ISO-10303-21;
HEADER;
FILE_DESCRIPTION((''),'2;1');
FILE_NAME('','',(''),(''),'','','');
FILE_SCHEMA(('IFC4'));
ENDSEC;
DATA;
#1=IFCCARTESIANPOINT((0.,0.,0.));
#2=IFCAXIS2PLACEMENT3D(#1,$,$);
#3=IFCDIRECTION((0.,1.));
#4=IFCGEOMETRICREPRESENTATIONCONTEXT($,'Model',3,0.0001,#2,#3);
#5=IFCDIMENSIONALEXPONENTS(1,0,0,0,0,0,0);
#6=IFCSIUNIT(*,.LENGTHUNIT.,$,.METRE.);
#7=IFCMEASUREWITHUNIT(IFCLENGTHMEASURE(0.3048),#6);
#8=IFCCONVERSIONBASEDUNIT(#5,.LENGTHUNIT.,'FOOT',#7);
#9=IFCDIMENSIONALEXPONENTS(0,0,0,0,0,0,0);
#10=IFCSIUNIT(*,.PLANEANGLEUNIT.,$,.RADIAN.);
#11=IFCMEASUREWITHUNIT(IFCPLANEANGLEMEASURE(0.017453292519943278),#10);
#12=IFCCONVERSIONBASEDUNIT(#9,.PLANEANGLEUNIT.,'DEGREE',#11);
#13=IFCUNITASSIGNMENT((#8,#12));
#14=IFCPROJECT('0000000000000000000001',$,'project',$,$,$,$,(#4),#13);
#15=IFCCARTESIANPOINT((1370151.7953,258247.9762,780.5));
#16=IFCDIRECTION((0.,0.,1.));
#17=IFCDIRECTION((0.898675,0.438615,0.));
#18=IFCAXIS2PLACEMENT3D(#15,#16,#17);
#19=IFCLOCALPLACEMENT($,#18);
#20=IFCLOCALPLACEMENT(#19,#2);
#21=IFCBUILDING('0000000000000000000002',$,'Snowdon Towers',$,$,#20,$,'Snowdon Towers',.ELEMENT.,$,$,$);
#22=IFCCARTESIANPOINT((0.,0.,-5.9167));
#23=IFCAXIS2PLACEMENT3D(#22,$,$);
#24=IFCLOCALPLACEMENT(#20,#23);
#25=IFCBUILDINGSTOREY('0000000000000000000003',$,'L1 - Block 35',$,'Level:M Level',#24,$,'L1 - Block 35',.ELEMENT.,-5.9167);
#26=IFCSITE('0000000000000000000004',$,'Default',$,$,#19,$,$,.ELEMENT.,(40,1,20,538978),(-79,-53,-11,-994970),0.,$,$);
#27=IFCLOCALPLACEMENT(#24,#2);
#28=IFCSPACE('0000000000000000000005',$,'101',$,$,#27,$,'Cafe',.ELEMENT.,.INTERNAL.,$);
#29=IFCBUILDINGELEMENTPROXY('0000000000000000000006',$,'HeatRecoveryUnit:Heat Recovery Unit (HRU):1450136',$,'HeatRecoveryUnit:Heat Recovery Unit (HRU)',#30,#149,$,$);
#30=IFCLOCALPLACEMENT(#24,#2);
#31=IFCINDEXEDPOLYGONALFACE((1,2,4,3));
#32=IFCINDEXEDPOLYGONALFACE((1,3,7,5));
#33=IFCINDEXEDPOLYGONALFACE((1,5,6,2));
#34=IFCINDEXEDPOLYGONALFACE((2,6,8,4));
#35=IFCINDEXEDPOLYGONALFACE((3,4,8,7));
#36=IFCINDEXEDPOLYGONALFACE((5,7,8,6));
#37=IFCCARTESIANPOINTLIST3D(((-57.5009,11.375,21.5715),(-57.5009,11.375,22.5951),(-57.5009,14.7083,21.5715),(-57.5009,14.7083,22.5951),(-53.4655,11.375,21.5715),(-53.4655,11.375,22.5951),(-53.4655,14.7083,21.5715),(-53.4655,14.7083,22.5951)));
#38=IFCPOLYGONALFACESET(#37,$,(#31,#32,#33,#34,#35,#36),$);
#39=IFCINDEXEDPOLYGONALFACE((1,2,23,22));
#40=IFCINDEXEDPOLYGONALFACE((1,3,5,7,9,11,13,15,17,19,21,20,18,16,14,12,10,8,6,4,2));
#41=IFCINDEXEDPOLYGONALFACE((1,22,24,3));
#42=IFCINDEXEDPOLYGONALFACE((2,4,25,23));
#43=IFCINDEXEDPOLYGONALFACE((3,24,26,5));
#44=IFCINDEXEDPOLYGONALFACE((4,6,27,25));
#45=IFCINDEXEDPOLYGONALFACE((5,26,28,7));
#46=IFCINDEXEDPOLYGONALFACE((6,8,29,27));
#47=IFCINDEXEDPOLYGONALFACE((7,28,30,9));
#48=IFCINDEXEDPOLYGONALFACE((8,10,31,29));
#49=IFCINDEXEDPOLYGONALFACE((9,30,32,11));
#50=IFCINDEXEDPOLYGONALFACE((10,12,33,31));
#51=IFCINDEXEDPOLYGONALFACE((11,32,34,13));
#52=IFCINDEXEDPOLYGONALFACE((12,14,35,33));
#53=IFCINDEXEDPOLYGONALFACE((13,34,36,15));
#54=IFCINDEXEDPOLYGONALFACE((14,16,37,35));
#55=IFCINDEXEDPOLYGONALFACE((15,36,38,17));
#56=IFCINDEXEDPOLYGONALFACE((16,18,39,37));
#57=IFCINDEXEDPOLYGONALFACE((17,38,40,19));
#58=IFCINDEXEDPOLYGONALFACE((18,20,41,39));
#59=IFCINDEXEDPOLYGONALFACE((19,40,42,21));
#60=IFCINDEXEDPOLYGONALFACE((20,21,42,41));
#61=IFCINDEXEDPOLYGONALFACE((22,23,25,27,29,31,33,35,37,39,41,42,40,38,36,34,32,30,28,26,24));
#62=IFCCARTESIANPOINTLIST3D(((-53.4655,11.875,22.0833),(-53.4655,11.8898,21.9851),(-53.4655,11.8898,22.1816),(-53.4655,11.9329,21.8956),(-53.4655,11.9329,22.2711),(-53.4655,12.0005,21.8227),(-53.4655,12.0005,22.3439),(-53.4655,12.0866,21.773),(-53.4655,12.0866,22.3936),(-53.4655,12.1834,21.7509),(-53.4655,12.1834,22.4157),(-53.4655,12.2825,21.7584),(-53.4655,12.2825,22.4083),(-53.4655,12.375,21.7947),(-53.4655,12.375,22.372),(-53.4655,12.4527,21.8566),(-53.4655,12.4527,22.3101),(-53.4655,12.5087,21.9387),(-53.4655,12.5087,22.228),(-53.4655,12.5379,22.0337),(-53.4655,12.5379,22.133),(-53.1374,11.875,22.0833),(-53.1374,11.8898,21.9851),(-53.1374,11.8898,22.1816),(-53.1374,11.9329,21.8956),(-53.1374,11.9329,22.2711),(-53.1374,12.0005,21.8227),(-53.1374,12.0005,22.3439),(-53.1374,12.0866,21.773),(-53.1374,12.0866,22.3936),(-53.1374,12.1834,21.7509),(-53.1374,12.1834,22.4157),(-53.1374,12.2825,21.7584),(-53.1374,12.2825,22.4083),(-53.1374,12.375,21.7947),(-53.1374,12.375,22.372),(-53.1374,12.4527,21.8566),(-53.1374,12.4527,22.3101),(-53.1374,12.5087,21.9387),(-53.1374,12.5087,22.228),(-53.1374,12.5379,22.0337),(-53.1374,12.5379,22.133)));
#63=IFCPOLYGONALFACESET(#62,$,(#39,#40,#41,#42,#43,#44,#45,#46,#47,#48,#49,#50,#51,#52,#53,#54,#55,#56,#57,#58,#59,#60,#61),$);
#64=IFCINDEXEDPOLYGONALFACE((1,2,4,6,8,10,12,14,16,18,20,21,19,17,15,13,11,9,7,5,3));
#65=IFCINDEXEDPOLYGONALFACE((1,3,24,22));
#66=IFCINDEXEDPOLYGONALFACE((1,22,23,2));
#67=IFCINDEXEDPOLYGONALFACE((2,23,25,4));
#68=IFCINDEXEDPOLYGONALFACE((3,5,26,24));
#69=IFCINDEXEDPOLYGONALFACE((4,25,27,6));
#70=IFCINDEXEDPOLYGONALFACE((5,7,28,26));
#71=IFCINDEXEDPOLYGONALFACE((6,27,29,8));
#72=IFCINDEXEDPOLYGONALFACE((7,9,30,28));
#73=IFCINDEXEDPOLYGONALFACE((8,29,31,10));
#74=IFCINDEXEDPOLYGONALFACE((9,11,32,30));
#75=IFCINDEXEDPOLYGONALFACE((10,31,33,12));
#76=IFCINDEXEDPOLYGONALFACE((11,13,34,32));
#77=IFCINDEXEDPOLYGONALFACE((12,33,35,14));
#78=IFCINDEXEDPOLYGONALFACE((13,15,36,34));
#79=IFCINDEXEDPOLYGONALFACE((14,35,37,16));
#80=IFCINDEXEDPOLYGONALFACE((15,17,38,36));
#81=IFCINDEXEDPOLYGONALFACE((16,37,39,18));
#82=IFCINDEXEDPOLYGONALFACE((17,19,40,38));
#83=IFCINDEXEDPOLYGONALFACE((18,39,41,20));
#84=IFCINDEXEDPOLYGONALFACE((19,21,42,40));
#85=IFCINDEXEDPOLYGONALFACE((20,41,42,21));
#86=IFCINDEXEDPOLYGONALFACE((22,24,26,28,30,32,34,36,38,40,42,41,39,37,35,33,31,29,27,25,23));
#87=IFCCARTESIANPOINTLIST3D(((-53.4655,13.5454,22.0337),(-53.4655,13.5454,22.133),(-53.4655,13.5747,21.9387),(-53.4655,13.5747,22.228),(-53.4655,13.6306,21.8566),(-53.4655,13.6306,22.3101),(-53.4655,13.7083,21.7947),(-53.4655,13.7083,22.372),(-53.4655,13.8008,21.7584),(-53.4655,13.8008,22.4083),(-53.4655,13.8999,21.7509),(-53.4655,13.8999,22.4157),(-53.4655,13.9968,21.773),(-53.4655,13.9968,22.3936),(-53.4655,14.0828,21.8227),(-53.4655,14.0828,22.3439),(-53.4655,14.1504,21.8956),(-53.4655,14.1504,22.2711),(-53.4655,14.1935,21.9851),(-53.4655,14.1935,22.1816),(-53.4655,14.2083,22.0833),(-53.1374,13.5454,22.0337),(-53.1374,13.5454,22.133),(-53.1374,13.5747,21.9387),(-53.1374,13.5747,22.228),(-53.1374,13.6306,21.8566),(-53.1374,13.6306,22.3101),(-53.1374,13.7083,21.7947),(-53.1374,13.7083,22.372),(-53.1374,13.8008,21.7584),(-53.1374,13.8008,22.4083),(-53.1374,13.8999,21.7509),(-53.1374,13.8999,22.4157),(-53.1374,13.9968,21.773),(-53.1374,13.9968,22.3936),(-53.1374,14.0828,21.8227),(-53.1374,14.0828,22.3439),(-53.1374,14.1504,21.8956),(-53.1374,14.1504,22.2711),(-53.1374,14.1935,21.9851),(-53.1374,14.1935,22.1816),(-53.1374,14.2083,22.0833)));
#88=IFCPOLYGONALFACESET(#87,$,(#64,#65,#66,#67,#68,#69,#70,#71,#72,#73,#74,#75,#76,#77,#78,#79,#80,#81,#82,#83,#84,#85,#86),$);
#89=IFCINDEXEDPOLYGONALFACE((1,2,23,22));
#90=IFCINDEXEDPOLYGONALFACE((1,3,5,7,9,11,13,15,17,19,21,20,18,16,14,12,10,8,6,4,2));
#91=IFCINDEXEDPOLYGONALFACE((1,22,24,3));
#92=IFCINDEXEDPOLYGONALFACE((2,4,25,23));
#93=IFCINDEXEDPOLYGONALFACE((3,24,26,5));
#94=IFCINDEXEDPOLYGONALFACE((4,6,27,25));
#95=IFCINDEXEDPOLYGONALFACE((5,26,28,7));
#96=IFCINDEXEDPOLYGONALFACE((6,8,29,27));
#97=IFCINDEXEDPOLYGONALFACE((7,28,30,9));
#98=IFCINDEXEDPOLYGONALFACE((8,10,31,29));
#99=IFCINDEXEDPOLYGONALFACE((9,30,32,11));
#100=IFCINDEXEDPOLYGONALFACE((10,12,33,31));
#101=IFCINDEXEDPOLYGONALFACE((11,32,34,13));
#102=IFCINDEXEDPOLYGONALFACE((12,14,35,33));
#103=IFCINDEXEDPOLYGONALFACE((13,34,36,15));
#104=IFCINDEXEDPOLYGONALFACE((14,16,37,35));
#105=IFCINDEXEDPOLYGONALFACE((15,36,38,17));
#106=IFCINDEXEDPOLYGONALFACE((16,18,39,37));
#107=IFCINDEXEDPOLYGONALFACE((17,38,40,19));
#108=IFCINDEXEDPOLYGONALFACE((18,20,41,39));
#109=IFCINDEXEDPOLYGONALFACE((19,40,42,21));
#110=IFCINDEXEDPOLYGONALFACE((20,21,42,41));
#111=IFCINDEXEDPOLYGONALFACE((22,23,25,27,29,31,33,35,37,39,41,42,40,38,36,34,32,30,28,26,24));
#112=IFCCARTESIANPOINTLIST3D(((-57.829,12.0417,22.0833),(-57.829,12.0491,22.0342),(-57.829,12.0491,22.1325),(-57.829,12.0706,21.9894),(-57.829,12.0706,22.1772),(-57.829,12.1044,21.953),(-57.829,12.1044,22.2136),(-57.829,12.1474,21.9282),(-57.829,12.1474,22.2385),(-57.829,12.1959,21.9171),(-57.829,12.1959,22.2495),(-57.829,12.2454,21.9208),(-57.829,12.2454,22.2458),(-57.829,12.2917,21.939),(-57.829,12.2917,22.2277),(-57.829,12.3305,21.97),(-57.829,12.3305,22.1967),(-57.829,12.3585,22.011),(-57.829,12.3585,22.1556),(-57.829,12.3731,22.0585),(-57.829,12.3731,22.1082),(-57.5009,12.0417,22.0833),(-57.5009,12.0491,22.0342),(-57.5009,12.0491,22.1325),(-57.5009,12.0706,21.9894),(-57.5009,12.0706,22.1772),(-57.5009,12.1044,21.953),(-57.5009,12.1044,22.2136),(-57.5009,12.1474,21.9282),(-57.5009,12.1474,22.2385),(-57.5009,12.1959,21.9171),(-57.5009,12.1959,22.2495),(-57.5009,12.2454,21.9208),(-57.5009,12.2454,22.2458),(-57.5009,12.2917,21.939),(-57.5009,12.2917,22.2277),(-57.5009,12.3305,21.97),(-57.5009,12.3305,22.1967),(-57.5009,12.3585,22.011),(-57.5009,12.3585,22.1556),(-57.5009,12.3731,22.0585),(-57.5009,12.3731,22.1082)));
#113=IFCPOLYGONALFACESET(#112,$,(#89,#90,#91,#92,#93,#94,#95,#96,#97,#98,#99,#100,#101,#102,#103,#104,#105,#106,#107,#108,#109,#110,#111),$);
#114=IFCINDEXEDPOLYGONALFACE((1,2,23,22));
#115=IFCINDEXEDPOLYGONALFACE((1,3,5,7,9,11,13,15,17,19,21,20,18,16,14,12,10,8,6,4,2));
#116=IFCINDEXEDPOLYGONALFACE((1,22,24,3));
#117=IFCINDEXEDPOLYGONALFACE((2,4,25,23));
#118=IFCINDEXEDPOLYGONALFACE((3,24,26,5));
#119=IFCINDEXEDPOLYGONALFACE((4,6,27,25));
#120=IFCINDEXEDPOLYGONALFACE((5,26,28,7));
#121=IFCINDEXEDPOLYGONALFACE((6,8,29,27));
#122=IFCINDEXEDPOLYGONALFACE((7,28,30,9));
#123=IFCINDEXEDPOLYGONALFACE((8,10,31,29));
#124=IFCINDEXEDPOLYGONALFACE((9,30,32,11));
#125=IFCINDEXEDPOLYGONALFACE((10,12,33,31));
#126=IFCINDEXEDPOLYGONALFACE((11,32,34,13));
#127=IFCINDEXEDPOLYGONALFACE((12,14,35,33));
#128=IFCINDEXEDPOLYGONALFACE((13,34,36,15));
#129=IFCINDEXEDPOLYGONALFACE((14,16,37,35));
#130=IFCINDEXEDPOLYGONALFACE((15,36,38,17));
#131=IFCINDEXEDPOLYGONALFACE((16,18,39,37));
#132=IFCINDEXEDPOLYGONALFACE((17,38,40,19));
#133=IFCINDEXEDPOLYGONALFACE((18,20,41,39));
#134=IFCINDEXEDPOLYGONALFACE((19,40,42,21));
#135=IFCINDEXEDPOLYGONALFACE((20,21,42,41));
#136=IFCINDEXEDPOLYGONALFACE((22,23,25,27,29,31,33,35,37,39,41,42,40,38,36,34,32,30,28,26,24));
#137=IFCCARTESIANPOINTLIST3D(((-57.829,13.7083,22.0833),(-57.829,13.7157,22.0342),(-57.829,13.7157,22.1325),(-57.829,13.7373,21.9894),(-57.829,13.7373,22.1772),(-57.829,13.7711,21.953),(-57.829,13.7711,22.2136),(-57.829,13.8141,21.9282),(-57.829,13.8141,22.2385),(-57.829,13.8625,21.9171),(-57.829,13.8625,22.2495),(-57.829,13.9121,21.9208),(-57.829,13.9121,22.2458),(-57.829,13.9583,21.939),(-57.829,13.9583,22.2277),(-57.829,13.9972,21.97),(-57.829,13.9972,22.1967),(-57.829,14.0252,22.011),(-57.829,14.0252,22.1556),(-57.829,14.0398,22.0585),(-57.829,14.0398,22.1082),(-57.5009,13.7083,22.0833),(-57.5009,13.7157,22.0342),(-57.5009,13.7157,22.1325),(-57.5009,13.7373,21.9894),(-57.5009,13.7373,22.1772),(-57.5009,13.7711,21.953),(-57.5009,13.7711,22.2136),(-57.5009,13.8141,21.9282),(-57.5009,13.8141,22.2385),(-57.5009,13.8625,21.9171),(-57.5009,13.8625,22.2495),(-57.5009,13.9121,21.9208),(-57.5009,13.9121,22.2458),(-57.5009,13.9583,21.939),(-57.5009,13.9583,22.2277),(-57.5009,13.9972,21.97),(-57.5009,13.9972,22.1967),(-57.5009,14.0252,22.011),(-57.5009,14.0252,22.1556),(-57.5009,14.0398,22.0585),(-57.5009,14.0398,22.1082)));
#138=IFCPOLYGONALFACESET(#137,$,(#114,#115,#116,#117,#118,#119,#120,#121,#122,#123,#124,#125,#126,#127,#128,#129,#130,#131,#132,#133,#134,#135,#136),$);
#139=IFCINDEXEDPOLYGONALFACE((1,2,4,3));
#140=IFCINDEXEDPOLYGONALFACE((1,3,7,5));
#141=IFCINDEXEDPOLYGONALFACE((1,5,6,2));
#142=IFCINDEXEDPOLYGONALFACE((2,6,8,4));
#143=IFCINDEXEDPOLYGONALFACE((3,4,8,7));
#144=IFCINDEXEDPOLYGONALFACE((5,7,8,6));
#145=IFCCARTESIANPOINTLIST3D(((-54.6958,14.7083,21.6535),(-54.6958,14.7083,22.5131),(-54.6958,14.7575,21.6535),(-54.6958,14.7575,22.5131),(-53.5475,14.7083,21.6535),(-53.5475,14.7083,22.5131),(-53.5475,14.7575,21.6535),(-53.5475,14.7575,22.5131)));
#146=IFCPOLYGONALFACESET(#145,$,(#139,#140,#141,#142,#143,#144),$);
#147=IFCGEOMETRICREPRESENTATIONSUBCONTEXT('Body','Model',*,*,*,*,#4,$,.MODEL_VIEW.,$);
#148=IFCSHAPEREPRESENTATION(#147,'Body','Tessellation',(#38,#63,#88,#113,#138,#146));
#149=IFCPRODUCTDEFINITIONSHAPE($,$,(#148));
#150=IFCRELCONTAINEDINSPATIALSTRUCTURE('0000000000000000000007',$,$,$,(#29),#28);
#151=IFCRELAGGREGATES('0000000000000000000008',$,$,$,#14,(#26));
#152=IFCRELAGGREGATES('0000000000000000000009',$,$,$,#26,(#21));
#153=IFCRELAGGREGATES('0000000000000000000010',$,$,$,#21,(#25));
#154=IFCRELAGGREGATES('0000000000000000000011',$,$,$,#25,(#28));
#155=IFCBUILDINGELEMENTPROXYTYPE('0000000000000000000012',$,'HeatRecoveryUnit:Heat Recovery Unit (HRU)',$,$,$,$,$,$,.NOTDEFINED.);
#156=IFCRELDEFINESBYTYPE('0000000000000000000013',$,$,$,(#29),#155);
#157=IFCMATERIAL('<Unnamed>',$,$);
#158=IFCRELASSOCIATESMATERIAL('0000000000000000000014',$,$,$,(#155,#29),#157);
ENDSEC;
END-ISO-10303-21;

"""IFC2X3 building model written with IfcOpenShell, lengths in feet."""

from ifc_helpers import new_model, entity, si_unit, converted_unit, direction, frame, frame_2d, origin, origin_2d_with_axis, place, context, subcontext, project, spatial, rectangle, circle, extrude, source, transform, mapped, material, type_object, type_shapes, element, save


model = new_model("IFC2X3")

# Units and contexts
model_context = context("Model", 3, precision=0.0001, world=origin(), true_north=direction((0.0, 1.0)))
body_context = subcontext(model_context, "Body", "Model", "MODEL_VIEW")
ifc_project = project(units=[converted_unit("LENGTHUNIT", "FOOT", entity("IfcLengthMeasure", 0.3048), si_unit("LENGTHUNIT", "METRE"), dimensions=[1, 0, 0, 0, 0, 0, 0]), converted_unit("PLANEANGLEUNIT", "DEGREE", entity("IfcPlaneAngleMeasure", 0.017453292519943278), si_unit("PLANEANGLEUNIT", "RADIAN"), dimensions=[0, 0, 0, 0, 0, 0, 0])], contexts=[model_context])

# Site, building, storey
site_placement = place(None, frame((1370151.7953, 258247.9762, 780.5), z_axis=(0.0, 0.0, 1.0), x_axis=(0.898675, 0.438615, 0.0)))
site = spatial("IfcSite", under=ifc_project, at=site_placement, Name="Default", CompositionType="ELEMENT", RefLatitude=(40, 1, 20, 538978), RefLongitude=(-79, -53, -11, -994970), RefElevation=0.0)
building_placement = place(site_placement, origin())
building = spatial("IfcBuilding", under=site, at=building_placement, Name="Snowdon Towers", LongName="Snowdon Towers", CompositionType="ELEMENT")
storey_placement = place(building_placement, frame((0.0, 0.0, -5.9167)))
storey = spatial("IfcBuildingStorey", under=building, at=storey_placement, Name="L1 - Block 35", ObjectType="Level:M Level", LongName="L1 - Block 35", CompositionType="ELEMENT", Elevation=-5.9167)

# Shared definitions
ifc_material = material(Name="<Unnamed>")

# Shared definitions
space_1_placement = place(storey_placement, origin())
space_1 = spatial("IfcSpace", under=storey, at=space_1_placement, Name="101", LongName="Cafe", CompositionType="ELEMENT", InteriorOrExteriorSpace="INTERNAL")

# Building element proxy
building_element_proxy_type = type_object("IfcBuildingElementProxyType", Name="HeatRecoveryUnit:Heat Recovery Unit (HRU)", PredefinedType="NOTDEFINED", material=ifc_material)
shared_shape_1 = source(origin(), body_context, "Body", "SweptSolid", [
    extrude(rectangle(XDim=3.3333, YDim=4.0354, at=origin_2d_with_axis()), frame((0.0, 0.0, 0.0), z_axis=(0.0, 0.0, 1.0), x_axis=(-1.0, 0.0, 0.0)), (0.0, 0.0, 1.0), 1.0236),
    extrude(circle(Radius=0.3333, at=frame_2d((0.0, 0.0), x_axis=(1.0, 0.0))), frame((-0.8333, -2.3458, 0.5118), z_axis=(0.0, 1.0, 0.0), x_axis=(-1.0, 0.0, 0.0)), (0.0, 0.0, 1.0), 0.3281),
    extrude(circle(Radius=0.3333, at=frame_2d((0.0, 0.0), x_axis=(1.0, 0.0))), frame((0.8333, -2.3458, 0.5118), z_axis=(0.0, 1.0, 0.0), x_axis=(1.0, 0.0, 0.0)), (0.0, 0.0, 1.0), 0.3281),
    extrude(circle(Radius=0.1667, at=frame_2d((0.0, 0.0), x_axis=(1.0, 0.0))), frame((-0.8333, 2.0177, 0.5118), z_axis=(0.0, 1.0, 0.0), x_axis=(-1.0, 0.0, 0.0)), (0.0, 0.0, 1.0), 0.3281),
    extrude(circle(Radius=0.1667, at=frame_2d((0.0, 0.0), x_axis=(1.0, 0.0))), frame((0.8333, 2.0177, 0.5118), z_axis=(0.0, 1.0, 0.0), x_axis=(-1.0, 0.0, 0.0)), (0.0, 0.0, 1.0), 0.3281),
    extrude(rectangle(XDim=0.0492, YDim=1.1483, at=origin_2d_with_axis()), frame((1.6913, -1.3615, 0.082), z_axis=(0.0, 0.0, 1.0), x_axis=(-1.0, 0.0, 0.0)), (0.0, 0.0, 1.0), 0.8596),
])
type_shapes(building_element_proxy_type, [shared_shape_1])
proxy_1_placement = place(space_1_placement, frame((-55.4832, 13.0417, 21.5715), z_axis=(0.0, 0.0, 1.0), x_axis=(0.0, 1.0, 0.0)))
element("IfcBuildingElementProxy", 1, at=proxy_1_placement, inside=space_1, type_object=building_element_proxy_type, material=ifc_material, Name="HeatRecoveryUnit:Heat Recovery Unit (HRU):1450136", ObjectType="HeatRecoveryUnit:Heat Recovery Unit (HRU)", context=body_context, shape_type="MappedRepresentation", body=[
    mapped(shared_shape_1, transform((0.0, 0.0, 0.0), scale=1.0)),
])

save(model, "model.ifc")
